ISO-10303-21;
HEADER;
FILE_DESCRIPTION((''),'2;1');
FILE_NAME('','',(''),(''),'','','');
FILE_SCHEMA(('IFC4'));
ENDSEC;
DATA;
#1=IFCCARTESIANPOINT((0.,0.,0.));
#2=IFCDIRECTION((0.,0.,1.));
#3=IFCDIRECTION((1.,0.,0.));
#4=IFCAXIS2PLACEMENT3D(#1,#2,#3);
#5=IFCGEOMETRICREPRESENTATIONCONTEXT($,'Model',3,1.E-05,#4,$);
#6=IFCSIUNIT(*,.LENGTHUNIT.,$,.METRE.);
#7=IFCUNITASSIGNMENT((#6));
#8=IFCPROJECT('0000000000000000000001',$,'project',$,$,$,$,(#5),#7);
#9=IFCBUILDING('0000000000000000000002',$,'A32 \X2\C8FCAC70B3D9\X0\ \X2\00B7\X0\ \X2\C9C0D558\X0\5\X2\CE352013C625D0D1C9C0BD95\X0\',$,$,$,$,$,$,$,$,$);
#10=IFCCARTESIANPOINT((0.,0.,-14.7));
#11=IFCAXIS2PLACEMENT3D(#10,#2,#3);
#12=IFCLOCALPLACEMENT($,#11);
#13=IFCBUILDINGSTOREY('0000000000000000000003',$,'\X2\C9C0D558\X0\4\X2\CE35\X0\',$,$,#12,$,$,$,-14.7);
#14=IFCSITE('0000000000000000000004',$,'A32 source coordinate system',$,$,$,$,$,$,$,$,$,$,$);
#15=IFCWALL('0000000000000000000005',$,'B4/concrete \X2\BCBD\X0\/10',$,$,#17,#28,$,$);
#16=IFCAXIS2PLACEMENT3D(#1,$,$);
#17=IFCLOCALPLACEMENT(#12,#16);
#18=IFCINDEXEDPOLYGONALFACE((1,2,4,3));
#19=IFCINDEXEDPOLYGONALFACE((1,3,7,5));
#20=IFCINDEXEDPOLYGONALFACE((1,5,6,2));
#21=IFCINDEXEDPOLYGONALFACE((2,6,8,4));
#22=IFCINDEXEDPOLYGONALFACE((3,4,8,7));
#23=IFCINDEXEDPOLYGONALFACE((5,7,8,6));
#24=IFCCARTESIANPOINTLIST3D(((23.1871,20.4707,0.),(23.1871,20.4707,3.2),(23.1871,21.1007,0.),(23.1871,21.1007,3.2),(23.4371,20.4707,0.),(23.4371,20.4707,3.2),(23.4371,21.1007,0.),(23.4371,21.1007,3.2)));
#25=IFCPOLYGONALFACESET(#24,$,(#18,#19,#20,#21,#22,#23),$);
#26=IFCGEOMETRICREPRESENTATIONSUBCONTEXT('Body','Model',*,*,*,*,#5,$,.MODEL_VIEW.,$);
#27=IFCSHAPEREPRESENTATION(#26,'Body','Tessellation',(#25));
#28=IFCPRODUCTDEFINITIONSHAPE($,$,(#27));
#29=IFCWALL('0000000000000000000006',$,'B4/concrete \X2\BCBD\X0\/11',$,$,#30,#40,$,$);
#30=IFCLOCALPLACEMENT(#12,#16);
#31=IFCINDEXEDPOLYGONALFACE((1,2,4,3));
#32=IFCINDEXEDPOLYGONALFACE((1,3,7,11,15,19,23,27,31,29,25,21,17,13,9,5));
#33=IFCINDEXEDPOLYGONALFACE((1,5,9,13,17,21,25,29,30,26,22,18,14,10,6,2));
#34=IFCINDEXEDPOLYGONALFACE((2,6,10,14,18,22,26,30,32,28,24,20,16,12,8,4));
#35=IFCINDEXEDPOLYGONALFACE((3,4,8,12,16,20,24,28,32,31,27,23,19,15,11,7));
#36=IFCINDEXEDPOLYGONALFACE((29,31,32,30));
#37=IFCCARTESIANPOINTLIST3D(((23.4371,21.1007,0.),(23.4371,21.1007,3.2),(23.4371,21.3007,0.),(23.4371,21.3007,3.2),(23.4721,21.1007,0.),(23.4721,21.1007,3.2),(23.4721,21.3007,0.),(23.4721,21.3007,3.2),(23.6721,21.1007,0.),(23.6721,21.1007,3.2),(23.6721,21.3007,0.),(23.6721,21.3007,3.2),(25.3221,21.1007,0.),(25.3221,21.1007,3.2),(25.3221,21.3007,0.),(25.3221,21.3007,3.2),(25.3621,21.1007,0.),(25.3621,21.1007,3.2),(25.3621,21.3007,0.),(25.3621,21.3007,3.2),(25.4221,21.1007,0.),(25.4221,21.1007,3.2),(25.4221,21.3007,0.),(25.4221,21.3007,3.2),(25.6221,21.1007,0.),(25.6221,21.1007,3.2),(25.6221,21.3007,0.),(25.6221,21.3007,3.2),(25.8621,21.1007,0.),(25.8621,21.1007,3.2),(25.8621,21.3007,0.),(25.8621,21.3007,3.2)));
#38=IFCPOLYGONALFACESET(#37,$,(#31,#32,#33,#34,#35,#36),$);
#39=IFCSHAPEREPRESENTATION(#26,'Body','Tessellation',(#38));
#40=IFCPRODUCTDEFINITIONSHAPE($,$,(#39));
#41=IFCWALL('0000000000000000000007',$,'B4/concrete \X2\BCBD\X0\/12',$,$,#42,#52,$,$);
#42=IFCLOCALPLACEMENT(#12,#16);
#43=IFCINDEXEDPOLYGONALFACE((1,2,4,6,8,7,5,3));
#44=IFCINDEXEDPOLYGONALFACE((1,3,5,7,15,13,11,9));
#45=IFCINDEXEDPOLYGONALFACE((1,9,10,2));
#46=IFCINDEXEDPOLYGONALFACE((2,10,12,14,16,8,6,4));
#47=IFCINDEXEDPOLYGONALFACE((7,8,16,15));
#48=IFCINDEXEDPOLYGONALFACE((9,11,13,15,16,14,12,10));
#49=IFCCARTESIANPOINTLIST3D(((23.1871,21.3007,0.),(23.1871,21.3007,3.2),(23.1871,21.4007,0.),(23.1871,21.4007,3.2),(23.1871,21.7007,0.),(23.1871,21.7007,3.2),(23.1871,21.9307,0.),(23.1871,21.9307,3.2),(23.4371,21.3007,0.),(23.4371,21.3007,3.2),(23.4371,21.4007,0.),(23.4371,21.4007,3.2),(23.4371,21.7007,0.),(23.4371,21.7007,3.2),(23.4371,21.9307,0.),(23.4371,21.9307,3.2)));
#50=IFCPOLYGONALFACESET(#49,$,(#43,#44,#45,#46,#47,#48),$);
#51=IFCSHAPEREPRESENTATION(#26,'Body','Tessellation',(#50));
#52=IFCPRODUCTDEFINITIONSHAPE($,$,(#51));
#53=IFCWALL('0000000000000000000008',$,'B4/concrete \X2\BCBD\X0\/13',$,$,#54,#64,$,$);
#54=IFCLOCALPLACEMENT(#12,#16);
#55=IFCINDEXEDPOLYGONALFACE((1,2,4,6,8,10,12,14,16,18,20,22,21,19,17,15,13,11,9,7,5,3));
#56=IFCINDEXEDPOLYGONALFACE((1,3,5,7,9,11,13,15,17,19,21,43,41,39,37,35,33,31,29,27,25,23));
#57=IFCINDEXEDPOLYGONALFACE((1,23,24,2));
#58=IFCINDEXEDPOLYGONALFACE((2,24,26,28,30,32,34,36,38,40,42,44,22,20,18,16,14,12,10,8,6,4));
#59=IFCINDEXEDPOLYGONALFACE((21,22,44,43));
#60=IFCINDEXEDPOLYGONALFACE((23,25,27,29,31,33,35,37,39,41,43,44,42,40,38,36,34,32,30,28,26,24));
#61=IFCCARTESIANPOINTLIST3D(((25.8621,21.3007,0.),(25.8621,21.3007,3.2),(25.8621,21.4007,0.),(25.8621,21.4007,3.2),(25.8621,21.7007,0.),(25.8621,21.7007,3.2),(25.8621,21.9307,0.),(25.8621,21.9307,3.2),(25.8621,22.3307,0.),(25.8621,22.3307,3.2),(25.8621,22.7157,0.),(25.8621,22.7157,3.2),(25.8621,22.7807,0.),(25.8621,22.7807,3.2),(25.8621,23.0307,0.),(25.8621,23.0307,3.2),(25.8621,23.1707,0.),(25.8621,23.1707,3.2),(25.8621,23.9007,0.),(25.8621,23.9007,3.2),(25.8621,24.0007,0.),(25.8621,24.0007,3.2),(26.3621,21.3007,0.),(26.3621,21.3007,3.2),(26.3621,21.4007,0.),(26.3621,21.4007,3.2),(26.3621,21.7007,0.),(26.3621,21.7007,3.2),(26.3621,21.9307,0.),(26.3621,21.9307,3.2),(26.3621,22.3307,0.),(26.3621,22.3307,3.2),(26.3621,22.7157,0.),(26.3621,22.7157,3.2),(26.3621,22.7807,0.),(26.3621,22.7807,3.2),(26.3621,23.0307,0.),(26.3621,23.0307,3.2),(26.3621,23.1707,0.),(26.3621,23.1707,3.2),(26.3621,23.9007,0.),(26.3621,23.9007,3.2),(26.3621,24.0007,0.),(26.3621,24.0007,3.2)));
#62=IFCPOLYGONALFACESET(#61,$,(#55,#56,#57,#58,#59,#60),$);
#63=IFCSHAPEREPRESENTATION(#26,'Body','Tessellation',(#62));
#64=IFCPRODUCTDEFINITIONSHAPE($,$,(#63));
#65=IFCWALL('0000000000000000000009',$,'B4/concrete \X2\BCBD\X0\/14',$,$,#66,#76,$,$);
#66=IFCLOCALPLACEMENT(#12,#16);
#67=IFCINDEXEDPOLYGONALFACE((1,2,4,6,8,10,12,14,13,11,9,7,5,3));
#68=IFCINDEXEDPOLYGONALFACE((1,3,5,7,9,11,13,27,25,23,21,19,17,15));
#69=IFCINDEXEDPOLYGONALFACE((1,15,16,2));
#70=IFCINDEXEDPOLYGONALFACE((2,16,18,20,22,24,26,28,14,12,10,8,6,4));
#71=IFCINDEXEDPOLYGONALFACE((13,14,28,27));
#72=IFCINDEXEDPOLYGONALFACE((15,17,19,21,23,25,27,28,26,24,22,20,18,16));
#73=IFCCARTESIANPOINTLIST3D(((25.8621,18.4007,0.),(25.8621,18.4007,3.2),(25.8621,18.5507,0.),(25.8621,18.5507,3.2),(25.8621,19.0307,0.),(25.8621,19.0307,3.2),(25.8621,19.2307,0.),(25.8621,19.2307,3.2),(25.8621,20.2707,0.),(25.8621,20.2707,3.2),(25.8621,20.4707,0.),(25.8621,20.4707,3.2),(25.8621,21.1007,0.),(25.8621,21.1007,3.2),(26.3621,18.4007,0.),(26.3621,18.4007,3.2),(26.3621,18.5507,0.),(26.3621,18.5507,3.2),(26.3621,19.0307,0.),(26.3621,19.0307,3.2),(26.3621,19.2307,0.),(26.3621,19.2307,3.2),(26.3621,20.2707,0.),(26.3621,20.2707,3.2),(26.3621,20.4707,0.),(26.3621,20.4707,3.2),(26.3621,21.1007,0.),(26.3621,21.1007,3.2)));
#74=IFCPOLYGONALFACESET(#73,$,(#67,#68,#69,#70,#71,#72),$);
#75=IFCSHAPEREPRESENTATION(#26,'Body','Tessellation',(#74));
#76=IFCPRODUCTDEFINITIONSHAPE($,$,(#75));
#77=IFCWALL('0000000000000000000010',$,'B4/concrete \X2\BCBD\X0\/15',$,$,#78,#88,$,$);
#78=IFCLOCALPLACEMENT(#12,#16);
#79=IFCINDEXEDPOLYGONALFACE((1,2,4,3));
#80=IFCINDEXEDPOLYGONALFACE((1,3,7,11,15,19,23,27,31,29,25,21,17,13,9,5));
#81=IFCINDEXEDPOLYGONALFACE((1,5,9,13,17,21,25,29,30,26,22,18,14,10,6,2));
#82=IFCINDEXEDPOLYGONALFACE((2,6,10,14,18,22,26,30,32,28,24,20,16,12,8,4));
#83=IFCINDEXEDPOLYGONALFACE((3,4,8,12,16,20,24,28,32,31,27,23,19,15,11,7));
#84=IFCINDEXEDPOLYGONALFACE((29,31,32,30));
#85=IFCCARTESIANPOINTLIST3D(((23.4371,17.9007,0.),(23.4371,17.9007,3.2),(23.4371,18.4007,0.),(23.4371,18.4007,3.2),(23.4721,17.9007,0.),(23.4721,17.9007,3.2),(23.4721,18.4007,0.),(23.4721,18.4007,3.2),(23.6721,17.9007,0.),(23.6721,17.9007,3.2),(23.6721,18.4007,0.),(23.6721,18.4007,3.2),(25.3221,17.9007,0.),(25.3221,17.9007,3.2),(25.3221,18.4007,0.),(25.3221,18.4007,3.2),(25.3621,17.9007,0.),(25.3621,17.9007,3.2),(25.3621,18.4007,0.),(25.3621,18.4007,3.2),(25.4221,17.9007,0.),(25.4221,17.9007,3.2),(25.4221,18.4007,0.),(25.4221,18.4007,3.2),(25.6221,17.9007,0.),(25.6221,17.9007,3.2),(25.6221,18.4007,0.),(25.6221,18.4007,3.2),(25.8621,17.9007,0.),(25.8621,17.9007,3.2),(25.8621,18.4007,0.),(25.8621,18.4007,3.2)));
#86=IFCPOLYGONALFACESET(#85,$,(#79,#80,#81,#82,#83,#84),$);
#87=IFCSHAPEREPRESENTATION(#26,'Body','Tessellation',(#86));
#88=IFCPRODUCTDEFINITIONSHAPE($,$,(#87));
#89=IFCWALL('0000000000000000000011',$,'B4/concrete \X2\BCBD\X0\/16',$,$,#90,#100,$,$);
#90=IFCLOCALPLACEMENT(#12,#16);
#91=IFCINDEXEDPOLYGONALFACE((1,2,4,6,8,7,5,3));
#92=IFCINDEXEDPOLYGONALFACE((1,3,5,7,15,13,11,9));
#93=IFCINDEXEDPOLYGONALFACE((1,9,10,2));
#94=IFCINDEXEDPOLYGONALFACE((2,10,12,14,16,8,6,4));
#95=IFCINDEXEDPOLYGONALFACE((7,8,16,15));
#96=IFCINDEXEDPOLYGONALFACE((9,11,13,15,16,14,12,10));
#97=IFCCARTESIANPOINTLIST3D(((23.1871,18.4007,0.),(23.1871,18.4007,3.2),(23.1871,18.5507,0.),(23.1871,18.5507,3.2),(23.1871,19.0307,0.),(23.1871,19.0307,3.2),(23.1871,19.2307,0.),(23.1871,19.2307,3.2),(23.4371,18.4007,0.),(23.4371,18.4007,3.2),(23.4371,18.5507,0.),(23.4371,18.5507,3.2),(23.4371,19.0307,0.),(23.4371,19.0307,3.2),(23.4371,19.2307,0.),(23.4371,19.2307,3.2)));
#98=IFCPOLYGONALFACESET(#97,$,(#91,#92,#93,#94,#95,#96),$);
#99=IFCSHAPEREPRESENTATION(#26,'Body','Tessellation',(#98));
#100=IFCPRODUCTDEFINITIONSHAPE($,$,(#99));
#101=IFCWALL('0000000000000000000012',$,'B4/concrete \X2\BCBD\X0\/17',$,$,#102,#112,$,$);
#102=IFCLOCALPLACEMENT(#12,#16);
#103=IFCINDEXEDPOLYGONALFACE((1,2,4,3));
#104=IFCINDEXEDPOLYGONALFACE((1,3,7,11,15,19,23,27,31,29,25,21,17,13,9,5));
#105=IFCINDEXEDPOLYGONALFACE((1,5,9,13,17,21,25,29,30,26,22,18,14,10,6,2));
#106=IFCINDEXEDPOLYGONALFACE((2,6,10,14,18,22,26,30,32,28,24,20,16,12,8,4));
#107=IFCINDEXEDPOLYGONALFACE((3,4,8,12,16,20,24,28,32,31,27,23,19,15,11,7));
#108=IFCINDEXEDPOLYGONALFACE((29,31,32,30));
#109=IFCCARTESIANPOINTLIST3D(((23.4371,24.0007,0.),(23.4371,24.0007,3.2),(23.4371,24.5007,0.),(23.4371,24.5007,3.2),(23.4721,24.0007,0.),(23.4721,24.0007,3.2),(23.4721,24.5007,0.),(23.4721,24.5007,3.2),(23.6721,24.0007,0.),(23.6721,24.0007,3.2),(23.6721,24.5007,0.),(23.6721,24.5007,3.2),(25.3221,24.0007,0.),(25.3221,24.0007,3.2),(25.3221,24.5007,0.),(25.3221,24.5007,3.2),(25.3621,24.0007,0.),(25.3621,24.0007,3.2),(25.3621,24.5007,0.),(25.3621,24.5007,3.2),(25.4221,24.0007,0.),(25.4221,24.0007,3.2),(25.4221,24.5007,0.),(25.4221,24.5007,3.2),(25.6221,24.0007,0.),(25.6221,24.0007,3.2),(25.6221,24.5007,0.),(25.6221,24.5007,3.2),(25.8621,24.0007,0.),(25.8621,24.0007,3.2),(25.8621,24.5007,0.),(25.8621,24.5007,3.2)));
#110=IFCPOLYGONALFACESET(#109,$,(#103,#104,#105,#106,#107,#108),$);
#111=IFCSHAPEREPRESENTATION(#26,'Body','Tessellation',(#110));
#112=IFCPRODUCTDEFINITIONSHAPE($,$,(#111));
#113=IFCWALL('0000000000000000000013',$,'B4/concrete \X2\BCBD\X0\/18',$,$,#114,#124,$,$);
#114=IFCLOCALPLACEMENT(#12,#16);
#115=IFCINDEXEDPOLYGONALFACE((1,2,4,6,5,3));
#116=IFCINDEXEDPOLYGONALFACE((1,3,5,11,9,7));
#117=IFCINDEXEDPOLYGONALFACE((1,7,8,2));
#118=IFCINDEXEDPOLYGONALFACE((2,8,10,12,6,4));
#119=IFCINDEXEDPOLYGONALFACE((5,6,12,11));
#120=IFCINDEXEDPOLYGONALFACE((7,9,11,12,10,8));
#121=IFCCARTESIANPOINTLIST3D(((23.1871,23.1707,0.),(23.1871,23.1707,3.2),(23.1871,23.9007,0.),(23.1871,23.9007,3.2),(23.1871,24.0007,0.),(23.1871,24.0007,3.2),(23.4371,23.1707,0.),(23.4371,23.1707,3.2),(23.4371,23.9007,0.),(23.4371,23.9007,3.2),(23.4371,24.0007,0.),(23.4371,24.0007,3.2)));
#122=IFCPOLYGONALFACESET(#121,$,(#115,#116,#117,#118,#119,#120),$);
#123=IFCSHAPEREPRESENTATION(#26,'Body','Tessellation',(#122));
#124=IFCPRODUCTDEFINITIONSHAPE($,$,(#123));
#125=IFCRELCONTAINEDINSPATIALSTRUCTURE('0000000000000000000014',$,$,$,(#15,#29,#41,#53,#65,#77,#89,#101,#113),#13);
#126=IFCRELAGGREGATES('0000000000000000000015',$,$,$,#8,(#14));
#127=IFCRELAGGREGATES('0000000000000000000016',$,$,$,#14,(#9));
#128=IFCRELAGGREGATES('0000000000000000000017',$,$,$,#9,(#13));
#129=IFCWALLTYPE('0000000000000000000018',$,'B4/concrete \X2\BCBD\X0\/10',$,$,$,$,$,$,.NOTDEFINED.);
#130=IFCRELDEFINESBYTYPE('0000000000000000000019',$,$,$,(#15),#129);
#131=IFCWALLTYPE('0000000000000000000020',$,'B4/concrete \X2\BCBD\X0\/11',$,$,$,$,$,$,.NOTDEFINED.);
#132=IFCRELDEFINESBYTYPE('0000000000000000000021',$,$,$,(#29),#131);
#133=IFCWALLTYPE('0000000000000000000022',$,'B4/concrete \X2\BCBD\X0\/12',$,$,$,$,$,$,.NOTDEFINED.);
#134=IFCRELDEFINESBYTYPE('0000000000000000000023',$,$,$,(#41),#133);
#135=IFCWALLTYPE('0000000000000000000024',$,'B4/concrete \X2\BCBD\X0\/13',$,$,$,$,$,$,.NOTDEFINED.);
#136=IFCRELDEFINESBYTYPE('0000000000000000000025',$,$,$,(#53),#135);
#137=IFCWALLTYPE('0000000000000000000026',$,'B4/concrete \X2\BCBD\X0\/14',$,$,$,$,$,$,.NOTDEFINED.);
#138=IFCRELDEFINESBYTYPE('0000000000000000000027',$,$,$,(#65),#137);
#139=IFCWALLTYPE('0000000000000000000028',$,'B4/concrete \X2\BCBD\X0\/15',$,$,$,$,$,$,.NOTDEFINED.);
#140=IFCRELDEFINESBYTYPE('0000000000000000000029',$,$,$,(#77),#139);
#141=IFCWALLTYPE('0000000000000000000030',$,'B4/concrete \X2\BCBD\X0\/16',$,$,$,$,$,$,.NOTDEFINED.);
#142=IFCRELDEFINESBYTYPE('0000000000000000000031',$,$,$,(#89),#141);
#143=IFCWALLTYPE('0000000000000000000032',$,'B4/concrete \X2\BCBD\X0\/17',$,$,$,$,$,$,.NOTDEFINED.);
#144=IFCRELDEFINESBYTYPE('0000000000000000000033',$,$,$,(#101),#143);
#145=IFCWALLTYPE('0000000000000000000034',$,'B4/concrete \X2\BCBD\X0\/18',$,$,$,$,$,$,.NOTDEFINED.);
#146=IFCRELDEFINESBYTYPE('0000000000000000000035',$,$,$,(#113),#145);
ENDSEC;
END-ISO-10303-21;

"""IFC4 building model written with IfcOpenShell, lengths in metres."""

from ifc_helpers import new_model, si_unit, frame, origin, origin_with_axes, place, context, subcontext, project, spatial, polyline, outline, extrude, source, transform, mapped, type_object, type_shapes, element, save


model = new_model("IFC4")

# Units and contexts
model_context = context("Model", 3, precision=1e-05, world=origin_with_axes())
body_context = subcontext(model_context, "Body", "Model", "MODEL_VIEW")
ifc_project = project(units=[si_unit("LENGTHUNIT", "METRE")], contexts=[model_context])

# Site, building, storey
site = spatial("IfcSite", under=ifc_project, Name="A32 source coordinate system")
building = spatial("IfcBuilding", under=site, Name="A32 주거동 · 지하5층–옥탑지붕")
storey_placement = place(None, frame((0.0, 0.0, -14.7), z_axis=(0.0, 0.0, 1.0), x_axis=(1.0, 0.0, 0.0)))
storey = spatial("IfcBuildingStorey", under=building, at=storey_placement, Name="지하4층", Elevation=-14.7)

# Walls
wall_type_1 = type_object("IfcWallType", Name="B4/concrete 벽/10", PredefinedType="NOTDEFINED")
shared_shape_1 = source(origin(), body_context, "Body", "SweptSolid", [
    extrude(outline(polyline([(23.1871, 20.4707), (23.1871, 21.1007), (23.4371, 21.1007), (23.4371, 20.4707), (23.1871, 20.4707)])), origin(), (0.0, 0.0, 1.0), 3.2),
])
type_shapes(wall_type_1, [shared_shape_1])
wall_1_placement = place(storey_placement, origin_with_axes())
element("IfcWall", 1, at=wall_1_placement, inside=storey, type_object=wall_type_1, Name="B4/concrete 벽/10", context=body_context, shape_type="MappedRepresentation", body=[
    mapped(shared_shape_1, transform((0.0, 0.0, 0.0), scale=1.0)),
])
wall_type_2 = type_object("IfcWallType", Name="B4/concrete 벽/11", PredefinedType="NOTDEFINED")
shared_shape_2 = source(origin(), body_context, "Body", "SweptSolid", [
    extrude(outline(polyline([(23.6721, 21.3007), (25.3221, 21.3007), (25.3621, 21.3007), (25.4221, 21.3007), (25.6221, 21.3007), (25.8621, 21.3007), (25.8621, 21.1007), (25.6221, 21.1007), (25.4221, 21.1007), (25.3621, 21.1007), (25.3221, 21.1007), (23.6721, 21.1007), (23.4721, 21.1007), (23.4371, 21.1007), (23.4371, 21.3007), (23.4721, 21.3007), (23.6721, 21.3007)])), origin(), (0.0, 0.0, 1.0), 3.2),
])
type_shapes(wall_type_2, [shared_shape_2])
wall_2_placement = place(storey_placement, origin_with_axes())
element("IfcWall", 2, at=wall_2_placement, inside=storey, type_object=wall_type_2, Name="B4/concrete 벽/11", context=body_context, shape_type="MappedRepresentation", body=[
    mapped(shared_shape_2, transform((0.0, 0.0, 0.0), scale=1.0)),
])
wall_type_3 = type_object("IfcWallType", Name="B4/concrete 벽/12", PredefinedType="NOTDEFINED")
shared_shape_3 = source(origin(), body_context, "Body", "SweptSolid", [
    extrude(outline(polyline([(23.1871, 21.7007), (23.1871, 21.9307), (23.4371, 21.9307), (23.4371, 21.7007), (23.4371, 21.4007), (23.4371, 21.3007), (23.1871, 21.3007), (23.1871, 21.4007), (23.1871, 21.7007)])), origin(), (0.0, 0.0, 1.0), 3.2),
])
type_shapes(wall_type_3, [shared_shape_3])
wall_3_placement = place(storey_placement, origin_with_axes())
element("IfcWall", 3, at=wall_3_placement, inside=storey, type_object=wall_type_3, Name="B4/concrete 벽/12", context=body_context, shape_type="MappedRepresentation", body=[
    mapped(shared_shape_3, transform((0.0, 0.0, 0.0), scale=1.0)),
])
wall_type_4 = type_object("IfcWallType", Name="B4/concrete 벽/13", PredefinedType="NOTDEFINED")
shared_shape_4 = source(origin(), body_context, "Body", "SweptSolid", [
    extrude(outline(polyline([(25.8621, 21.9307), (25.8621, 22.3307), (25.8621, 22.7157), (25.8621, 22.7807), (25.8621, 23.0307), (25.8621, 23.1707), (25.8621, 23.9007), (25.8621, 24.0007), (26.3621, 24.0007), (26.3621, 23.9007), (26.3621, 23.1707), (26.3621, 23.0307), (26.3621, 22.7807), (26.3621, 22.7157), (26.3621, 22.3307), (26.3621, 21.9307), (26.3621, 21.7007), (26.3621, 21.4007), (26.3621, 21.3007), (25.8621, 21.3007), (25.8621, 21.4007), (25.8621, 21.7007), (25.8621, 21.9307)])), origin(), (0.0, 0.0, 1.0), 3.2),
])
type_shapes(wall_type_4, [shared_shape_4])
wall_4_placement = place(storey_placement, origin_with_axes())
element("IfcWall", 4, at=wall_4_placement, inside=storey, type_object=wall_type_4, Name="B4/concrete 벽/13", context=body_context, shape_type="MappedRepresentation", body=[
    mapped(shared_shape_4, transform((0.0, 0.0, 0.0), scale=1.0)),
])
wall_type_5 = type_object("IfcWallType", Name="B4/concrete 벽/14", PredefinedType="NOTDEFINED")
shared_shape_5 = source(origin(), body_context, "Body", "SweptSolid", [
    extrude(outline(polyline([(26.3621, 20.2707), (26.3621, 19.2307), (26.3621, 19.0307), (26.3621, 18.5507), (26.3621, 18.4007), (25.8621, 18.4007), (25.8621, 18.5507), (25.8621, 19.0307), (25.8621, 19.2307), (25.8621, 20.2707), (25.8621, 20.4707), (25.8621, 21.1007), (26.3621, 21.1007), (26.3621, 20.4707), (26.3621, 20.2707)])), origin(), (0.0, 0.0, 1.0), 3.2),
])
type_shapes(wall_type_5, [shared_shape_5])
wall_5_placement = place(storey_placement, origin_with_axes())
element("IfcWall", 5, at=wall_5_placement, inside=storey, type_object=wall_type_5, Name="B4/concrete 벽/14", context=body_context, shape_type="MappedRepresentation", body=[
    mapped(shared_shape_5, transform((0.0, 0.0, 0.0), scale=1.0)),
])
wall_type_6 = type_object("IfcWallType", Name="B4/concrete 벽/15", PredefinedType="NOTDEFINED")
shared_shape_6 = source(origin(), body_context, "Body", "SweptSolid", [
    extrude(outline(polyline([(25.4221, 17.9007), (25.3621, 17.9007), (25.3221, 17.9007), (23.6721, 17.9007), (23.4721, 17.9007), (23.4371, 17.9007), (23.4371, 18.4007), (23.4721, 18.4007), (23.6721, 18.4007), (25.3221, 18.4007), (25.3621, 18.4007), (25.4221, 18.4007), (25.6221, 18.4007), (25.8621, 18.4007), (25.8621, 17.9007), (25.6221, 17.9007), (25.4221, 17.9007)])), origin(), (0.0, 0.0, 1.0), 3.2),
])
type_shapes(wall_type_6, [shared_shape_6])
wall_6_placement = place(storey_placement, origin_with_axes())
element("IfcWall", 6, at=wall_6_placement, inside=storey, type_object=wall_type_6, Name="B4/concrete 벽/15", context=body_context, shape_type="MappedRepresentation", body=[
    mapped(shared_shape_6, transform((0.0, 0.0, 0.0), scale=1.0)),
])
wall_type_7 = type_object("IfcWallType", Name="B4/concrete 벽/16", PredefinedType="NOTDEFINED")
shared_shape_7 = source(origin(), body_context, "Body", "SweptSolid", [
    extrude(outline(polyline([(23.1871, 19.0307), (23.1871, 19.2307), (23.4371, 19.2307), (23.4371, 19.0307), (23.4371, 18.5507), (23.4371, 18.4007), (23.1871, 18.4007), (23.1871, 18.5507), (23.1871, 19.0307)])), origin(), (0.0, 0.0, 1.0), 3.2),
])
type_shapes(wall_type_7, [shared_shape_7])
wall_7_placement = place(storey_placement, origin_with_axes())
element("IfcWall", 7, at=wall_7_placement, inside=storey, type_object=wall_type_7, Name="B4/concrete 벽/16", context=body_context, shape_type="MappedRepresentation", body=[
    mapped(shared_shape_7, transform((0.0, 0.0, 0.0), scale=1.0)),
])
wall_type_8 = type_object("IfcWallType", Name="B4/concrete 벽/17", PredefinedType="NOTDEFINED")
shared_shape_8 = source(origin(), body_context, "Body", "SweptSolid", [
    extrude(outline(polyline([(25.3621, 24.0007), (25.3221, 24.0007), (23.6721, 24.0007), (23.4721, 24.0007), (23.4371, 24.0007), (23.4371, 24.5007), (23.4721, 24.5007), (23.6721, 24.5007), (25.3221, 24.5007), (25.3621, 24.5007), (25.4221, 24.5007), (25.6221, 24.5007), (25.8621, 24.5007), (25.8621, 24.0007), (25.6221, 24.0007), (25.4221, 24.0007), (25.3621, 24.0007)])), origin(), (0.0, 0.0, 1.0), 3.2),
])
type_shapes(wall_type_8, [shared_shape_8])
wall_8_placement = place(storey_placement, origin_with_axes())
element("IfcWall", 8, at=wall_8_placement, inside=storey, type_object=wall_type_8, Name="B4/concrete 벽/17", context=body_context, shape_type="MappedRepresentation", body=[
    mapped(shared_shape_8, transform((0.0, 0.0, 0.0), scale=1.0)),
])
wall_type_9 = type_object("IfcWallType", Name="B4/concrete 벽/18", PredefinedType="NOTDEFINED")
shared_shape_9 = source(origin(), body_context, "Body", "SweptSolid", [
    extrude(outline(polyline([(23.1871, 23.1707), (23.1871, 23.9007), (23.1871, 24.0007), (23.4371, 24.0007), (23.4371, 23.9007), (23.4371, 23.1707), (23.1871, 23.1707)])), origin(), (0.0, 0.0, 1.0), 3.2),
])
type_shapes(wall_type_9, [shared_shape_9])
wall_9_placement = place(storey_placement, origin_with_axes())
element("IfcWall", 9, at=wall_9_placement, inside=storey, type_object=wall_type_9, Name="B4/concrete 벽/18", context=body_context, shape_type="MappedRepresentation", body=[
    mapped(shared_shape_9, transform((0.0, 0.0, 0.0), scale=1.0)),
])

save(model, "model.ifc")
